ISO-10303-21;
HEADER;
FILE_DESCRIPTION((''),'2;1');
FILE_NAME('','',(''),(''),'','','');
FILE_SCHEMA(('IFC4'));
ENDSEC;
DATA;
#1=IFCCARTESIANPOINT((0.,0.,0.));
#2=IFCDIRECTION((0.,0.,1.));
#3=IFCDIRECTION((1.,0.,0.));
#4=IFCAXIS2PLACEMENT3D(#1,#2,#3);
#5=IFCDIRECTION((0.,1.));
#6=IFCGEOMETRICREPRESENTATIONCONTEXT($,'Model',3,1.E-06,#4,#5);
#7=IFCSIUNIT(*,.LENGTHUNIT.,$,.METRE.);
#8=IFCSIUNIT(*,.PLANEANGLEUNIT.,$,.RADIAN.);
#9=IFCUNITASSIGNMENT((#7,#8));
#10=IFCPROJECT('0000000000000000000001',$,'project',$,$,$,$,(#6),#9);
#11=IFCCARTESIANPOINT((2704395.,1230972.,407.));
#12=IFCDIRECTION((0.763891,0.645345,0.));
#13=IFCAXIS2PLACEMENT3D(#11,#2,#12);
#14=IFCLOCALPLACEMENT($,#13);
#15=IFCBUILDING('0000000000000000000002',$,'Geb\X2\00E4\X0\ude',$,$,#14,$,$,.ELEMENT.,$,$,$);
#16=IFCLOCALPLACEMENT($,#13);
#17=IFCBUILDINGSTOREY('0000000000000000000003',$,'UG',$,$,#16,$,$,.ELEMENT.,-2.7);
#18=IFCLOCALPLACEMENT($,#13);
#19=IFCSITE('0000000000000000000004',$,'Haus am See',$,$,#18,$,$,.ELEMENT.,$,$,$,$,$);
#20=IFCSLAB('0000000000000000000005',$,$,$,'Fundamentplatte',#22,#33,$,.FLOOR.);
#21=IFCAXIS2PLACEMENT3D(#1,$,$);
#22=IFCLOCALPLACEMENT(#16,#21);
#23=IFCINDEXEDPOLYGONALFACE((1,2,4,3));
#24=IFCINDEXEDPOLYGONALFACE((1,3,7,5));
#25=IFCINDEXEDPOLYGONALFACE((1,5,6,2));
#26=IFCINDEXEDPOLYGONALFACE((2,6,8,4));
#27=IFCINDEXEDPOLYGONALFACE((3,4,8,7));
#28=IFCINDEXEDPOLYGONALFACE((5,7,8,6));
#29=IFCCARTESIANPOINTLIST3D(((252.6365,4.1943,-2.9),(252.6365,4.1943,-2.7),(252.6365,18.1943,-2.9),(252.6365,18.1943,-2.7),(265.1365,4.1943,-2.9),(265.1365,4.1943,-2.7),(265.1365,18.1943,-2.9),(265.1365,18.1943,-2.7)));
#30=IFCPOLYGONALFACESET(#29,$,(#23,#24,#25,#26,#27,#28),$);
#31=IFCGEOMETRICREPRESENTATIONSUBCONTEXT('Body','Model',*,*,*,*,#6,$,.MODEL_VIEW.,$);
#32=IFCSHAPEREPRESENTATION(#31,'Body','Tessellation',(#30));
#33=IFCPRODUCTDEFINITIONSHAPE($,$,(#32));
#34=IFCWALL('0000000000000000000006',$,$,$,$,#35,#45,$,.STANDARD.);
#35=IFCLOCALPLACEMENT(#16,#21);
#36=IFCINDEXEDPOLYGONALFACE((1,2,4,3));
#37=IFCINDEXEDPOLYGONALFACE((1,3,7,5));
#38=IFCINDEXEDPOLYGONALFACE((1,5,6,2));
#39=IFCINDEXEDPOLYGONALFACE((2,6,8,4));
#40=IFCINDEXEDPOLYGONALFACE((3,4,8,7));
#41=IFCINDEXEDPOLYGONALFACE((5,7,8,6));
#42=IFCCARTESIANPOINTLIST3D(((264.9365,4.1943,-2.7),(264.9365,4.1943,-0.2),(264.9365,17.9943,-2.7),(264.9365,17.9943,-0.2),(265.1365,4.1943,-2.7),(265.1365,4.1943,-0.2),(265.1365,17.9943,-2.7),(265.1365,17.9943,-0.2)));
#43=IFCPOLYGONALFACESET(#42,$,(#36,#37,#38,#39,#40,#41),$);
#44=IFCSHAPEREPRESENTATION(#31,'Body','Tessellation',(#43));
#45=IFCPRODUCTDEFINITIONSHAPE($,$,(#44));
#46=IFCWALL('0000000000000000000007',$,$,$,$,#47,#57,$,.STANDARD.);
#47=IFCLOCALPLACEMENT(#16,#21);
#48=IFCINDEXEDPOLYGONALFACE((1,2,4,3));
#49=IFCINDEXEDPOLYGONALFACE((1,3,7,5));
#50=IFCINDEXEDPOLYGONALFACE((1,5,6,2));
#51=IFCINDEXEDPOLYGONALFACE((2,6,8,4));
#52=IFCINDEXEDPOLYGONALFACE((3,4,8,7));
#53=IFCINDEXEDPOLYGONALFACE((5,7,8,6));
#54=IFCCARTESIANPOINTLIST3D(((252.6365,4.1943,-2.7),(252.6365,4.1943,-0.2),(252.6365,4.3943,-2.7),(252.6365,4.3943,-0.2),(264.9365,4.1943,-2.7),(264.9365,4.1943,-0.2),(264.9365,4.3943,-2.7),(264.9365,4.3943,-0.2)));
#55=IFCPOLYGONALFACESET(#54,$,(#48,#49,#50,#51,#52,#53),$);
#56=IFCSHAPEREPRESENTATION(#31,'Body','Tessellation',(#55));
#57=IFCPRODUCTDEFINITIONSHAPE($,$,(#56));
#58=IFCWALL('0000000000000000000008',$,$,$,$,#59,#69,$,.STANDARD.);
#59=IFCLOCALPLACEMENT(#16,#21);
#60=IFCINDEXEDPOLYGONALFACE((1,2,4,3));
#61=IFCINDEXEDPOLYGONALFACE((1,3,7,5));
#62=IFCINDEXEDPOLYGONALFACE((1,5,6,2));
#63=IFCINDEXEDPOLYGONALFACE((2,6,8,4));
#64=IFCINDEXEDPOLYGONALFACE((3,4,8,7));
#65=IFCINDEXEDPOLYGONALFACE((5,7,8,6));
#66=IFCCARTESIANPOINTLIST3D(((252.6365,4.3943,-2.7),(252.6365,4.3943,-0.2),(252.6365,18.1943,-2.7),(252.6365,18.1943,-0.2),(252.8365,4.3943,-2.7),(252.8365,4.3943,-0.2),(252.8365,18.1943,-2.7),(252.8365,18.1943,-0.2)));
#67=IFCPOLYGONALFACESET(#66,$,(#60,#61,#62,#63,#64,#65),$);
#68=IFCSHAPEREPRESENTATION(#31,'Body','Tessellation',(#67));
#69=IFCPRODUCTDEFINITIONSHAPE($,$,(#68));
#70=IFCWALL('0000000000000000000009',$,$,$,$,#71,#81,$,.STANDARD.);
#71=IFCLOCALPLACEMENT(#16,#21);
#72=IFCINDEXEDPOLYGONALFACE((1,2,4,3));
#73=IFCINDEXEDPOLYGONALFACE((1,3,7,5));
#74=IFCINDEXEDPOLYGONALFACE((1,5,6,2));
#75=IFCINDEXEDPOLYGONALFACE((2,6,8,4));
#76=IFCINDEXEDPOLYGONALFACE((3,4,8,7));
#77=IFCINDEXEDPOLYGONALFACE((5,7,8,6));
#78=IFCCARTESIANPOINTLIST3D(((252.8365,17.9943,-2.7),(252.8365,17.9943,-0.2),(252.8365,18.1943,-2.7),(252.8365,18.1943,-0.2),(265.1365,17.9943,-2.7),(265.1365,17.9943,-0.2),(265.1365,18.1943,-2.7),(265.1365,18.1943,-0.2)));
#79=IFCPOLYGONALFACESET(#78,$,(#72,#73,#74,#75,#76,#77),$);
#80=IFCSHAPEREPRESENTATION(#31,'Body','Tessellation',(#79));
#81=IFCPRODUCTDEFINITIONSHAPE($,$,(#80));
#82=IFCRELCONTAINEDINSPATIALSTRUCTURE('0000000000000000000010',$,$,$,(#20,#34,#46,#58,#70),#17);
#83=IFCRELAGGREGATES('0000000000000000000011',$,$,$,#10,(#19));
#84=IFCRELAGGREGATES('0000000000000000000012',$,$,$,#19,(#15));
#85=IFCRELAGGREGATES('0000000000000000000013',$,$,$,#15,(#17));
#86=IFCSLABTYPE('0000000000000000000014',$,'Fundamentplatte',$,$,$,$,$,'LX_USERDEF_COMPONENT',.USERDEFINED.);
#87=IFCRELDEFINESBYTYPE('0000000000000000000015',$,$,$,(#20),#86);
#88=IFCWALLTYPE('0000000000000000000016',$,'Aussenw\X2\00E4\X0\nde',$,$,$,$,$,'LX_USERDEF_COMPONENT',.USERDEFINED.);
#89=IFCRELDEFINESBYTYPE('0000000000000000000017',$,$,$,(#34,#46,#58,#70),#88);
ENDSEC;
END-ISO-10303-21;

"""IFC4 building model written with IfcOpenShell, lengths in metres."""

from ifc_helpers import new_model, si_unit, direction, frame, origin_with_axes, origin_2d_with_axis, place, context, subcontext, project, spatial, polyline, rectangle, outline, extrude, type_object, element, save


model = new_model("IFC4")

# Units and contexts
model_context = context("Model", 3, precision=1e-06, world=origin_with_axes(), true_north=direction((0.0, 1.0)))
body_context = subcontext(model_context, "Body", "Model", "MODEL_VIEW")
ifc_project = project(units=[si_unit("LENGTHUNIT", "METRE"), si_unit("PLANEANGLEUNIT", "RADIAN")], contexts=[model_context])

# Site, building, storey
site_placement = place(None, frame((2704395.0, 1230972.0, 407.0), z_axis=(0.0, 0.0, 1.0), x_axis=(0.763891, 0.645345, 0.0)))
site = spatial("IfcSite", under=ifc_project, at=site_placement, Name="Haus am See", CompositionType="ELEMENT")
building_placement = place(None, frame((2704395.0, 1230972.0, 407.0), z_axis=(0.0, 0.0, 1.0), x_axis=(0.763891, 0.645345, 0.0)))
building = spatial("IfcBuilding", under=site, at=building_placement, Name="Gebäude", CompositionType="ELEMENT")
storey_placement = place(None, frame((2704395.0, 1230972.0, 407.0), z_axis=(0.0, 0.0, 1.0), x_axis=(0.763891, 0.645345, 0.0)))
storey = spatial("IfcBuildingStorey", under=building, at=storey_placement, Name="UG", CompositionType="ELEMENT", Elevation=-2.7)

# Slab
slab_type = type_object("IfcSlabType", Name="Fundamentplatte", ElementType="LX_USERDEF_COMPONENT", PredefinedType="USERDEFINED")
slab_placement = place(storey_placement, frame((258.8865, 11.1943, -2.9), z_axis=(0.0, 0.0, 1.0), x_axis=(1.0, 0.0, 0.0)))
element("IfcSlab", 1, at=slab_placement, inside=storey, type_object=slab_type, ObjectType="Fundamentplatte", PredefinedType="FLOOR", context=body_context, shape_type="SweptSolid", body=[
    extrude(rectangle(XDim=12.5, YDim=14.0, at=origin_2d_with_axis()), origin_with_axes(), (0.0, 0.0, 1.0), 0.2),
])

# Walls
wall_type = type_object("IfcWallType", Name="Aussenwände", ElementType="LX_USERDEF_COMPONENT", PredefinedType="USERDEFINED")
wall_1_placement = place(storey_placement, frame((265.1365, 4.1943, -2.7), z_axis=(0.0, 0.0, 1.0), x_axis=(0.0, 1.0, 0.0)))
element("IfcWall", 2, at=wall_1_placement, inside=storey, type_object=wall_type, PredefinedType="STANDARD", context=body_context, shape_type="SweptSolid", body=[
    extrude(outline(polyline([(0.0, 0.0, 0.0), (13.8, 0.0, 0.0), (13.8, 0.2, 0.0), (0.0, 0.2, 0.0), (0.0, 0.0, 0.0)])), origin_with_axes(), (0.0, 0.0, 1.0), 2.5),
])
wall_2_placement = place(storey_placement, frame((252.6365, 4.1943, -2.7), z_axis=(0.0, 0.0, 1.0), x_axis=(1.0, 0.0, 0.0)))
element("IfcWall", 3, at=wall_2_placement, inside=storey, type_object=wall_type, PredefinedType="STANDARD", context=body_context, shape_type="SweptSolid", body=[
    extrude(outline(polyline([(0.0, 0.0, 0.0), (12.3, 0.0, 0.0), (12.3, 0.2, 0.0), (0.0, 0.2, 0.0), (0.0, 0.0, 0.0)])), origin_with_axes(), (0.0, 0.0, 1.0), 2.5),
])
wall_3_placement = place(storey_placement, frame((252.6365, 18.1943, -2.7), z_axis=(0.0, 0.0, 1.0), x_axis=(0.0, -1.0, 0.0)))
element("IfcWall", 4, at=wall_3_placement, inside=storey, type_object=wall_type, PredefinedType="STANDARD", context=body_context, shape_type="SweptSolid", body=[
    extrude(outline(polyline([(0.0, 0.0, 0.0), (13.8, 0.0, 0.0), (13.8, 0.2, 0.0), (0.0, 0.2, 0.0), (0.0, 0.0, 0.0)])), origin_with_axes(), (0.0, 0.0, 1.0), 2.5),
])
wall_4_placement = place(storey_placement, frame((265.1365, 18.1943, -2.7), z_axis=(0.0, 0.0, 1.0), x_axis=(-1.0, 0.0, 0.0)))
element("IfcWall", 5, at=wall_4_placement, inside=storey, type_object=wall_type, PredefinedType="STANDARD", context=body_context, shape_type="SweptSolid", body=[
    extrude(outline(polyline([(0.0, 0.0, 0.0), (12.3, 0.0, 0.0), (12.3, 0.2, 0.0), (0.0, 0.2, 0.0), (0.0, 0.0, 0.0)])), origin_with_axes(), (0.0, 0.0, 1.0), 2.5),
])

save(model, "model.ifc")
